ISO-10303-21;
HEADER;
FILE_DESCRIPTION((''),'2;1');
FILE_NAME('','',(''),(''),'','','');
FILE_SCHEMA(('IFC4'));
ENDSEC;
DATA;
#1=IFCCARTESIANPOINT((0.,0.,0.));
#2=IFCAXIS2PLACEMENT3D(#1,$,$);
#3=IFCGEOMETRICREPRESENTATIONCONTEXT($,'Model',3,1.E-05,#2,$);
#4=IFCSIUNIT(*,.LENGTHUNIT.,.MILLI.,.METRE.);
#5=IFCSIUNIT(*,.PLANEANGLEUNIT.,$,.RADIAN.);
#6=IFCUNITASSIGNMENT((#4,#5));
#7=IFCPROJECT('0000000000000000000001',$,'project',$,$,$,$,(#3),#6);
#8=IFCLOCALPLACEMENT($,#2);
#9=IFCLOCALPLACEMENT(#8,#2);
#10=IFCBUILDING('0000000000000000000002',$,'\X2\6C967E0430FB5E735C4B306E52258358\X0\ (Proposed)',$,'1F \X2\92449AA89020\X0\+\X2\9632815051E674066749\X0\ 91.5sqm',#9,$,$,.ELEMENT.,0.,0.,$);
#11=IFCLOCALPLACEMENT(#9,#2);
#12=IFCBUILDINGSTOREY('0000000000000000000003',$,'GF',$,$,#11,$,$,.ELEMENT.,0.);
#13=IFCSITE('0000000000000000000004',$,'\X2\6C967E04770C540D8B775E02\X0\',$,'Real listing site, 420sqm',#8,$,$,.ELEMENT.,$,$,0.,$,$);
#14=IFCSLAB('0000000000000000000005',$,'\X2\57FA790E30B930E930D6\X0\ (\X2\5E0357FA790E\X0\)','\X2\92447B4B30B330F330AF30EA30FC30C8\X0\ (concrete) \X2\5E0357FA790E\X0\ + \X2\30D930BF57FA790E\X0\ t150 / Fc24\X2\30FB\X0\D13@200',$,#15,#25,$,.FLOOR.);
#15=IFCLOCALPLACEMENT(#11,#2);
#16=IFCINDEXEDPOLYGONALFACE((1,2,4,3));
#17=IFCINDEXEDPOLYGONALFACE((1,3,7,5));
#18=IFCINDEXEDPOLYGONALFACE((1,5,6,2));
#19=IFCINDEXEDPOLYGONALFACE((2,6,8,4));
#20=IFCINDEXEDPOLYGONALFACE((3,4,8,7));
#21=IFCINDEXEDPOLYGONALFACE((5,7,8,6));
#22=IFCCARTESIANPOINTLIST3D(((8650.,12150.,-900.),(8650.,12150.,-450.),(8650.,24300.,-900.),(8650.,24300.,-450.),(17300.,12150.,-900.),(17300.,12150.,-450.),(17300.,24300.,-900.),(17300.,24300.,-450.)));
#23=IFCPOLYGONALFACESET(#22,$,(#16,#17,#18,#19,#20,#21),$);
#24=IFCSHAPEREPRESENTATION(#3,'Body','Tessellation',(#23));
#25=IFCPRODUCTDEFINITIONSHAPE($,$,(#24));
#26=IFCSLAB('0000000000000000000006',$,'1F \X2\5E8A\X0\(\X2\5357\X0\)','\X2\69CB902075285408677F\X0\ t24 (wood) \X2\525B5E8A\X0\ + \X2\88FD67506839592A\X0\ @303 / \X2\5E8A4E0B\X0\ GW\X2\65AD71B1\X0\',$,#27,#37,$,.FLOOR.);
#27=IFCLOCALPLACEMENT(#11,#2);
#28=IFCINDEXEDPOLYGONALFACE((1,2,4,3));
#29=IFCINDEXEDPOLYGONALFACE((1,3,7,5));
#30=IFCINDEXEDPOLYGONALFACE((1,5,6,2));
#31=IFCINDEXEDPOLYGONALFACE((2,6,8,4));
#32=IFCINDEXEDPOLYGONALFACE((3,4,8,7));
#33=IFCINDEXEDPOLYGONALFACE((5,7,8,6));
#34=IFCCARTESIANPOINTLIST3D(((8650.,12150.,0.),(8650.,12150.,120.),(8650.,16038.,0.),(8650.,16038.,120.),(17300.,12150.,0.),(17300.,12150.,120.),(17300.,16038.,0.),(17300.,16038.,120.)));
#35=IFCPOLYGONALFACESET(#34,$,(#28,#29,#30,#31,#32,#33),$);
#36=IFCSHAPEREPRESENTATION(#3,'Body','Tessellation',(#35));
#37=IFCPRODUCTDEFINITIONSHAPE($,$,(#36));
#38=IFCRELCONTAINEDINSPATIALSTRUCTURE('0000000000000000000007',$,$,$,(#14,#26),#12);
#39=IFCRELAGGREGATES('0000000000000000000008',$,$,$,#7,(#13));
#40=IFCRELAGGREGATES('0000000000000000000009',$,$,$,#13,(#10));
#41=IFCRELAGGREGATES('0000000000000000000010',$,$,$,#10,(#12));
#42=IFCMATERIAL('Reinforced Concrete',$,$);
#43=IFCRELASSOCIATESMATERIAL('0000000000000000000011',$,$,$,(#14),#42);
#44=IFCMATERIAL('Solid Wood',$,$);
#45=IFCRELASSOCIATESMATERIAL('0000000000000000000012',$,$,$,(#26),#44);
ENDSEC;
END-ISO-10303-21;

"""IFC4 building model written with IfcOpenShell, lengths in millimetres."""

from ifc_helpers import new_model, si_unit, frame, frame_2d, origin, place, context, project, spatial, rectangle, extrude, material, element, save


model = new_model("IFC4")

# Units and contexts
model_context = context("Model", 3, precision=1e-05, world=origin())
ifc_project = project(units=[si_unit("LENGTHUNIT", "METRE", prefix="MILLI"), si_unit("PLANEANGLEUNIT", "RADIAN")], contexts=[model_context])

# Site, building, storey
site_placement = place(None, origin())
site = spatial("IfcSite", under=ifc_project, at=site_placement, Name="沖縄県名護市", ObjectType="Real listing site, 420sqm", CompositionType="ELEMENT", RefElevation=0.0)
building_placement = place(site_placement, origin())
building = spatial("IfcBuilding", under=site, at=building_placement, Name="沖縄・平屋の別荘 (Proposed)", ObjectType="1F 鉄骨造+防腐処理杉 91.5sqm", CompositionType="ELEMENT", ElevationOfRefHeight=0.0, ElevationOfTerrain=0.0)
storey_placement = place(building_placement, origin())
storey = spatial("IfcBuildingStorey", under=building, at=storey_placement, Name="GF", CompositionType="ELEMENT", Elevation=0.0)

# Shared definitions
ifc_material_1 = material(Name="Solid Wood")

# Slabs
ifc_material_2 = material(Name="Reinforced Concrete")
slab_1_placement = place(storey_placement, frame((4325.0, 6075.0, -450.0)))
element("IfcSlab", 1, at=slab_1_placement, inside=storey, material=ifc_material_2, Name="基礎スラブ (布基礎)", Description="鉄筋コンクリート (concrete) 布基礎 + ベタ基礎 t150 / Fc24・D13@200", PredefinedType="FLOOR", context=model_context, shape_type="SweptSolid", body=[
    extrude(rectangle(XDim=8650.0, YDim=12150.0, at=frame_2d((4325.0, 6075.0))), frame((4325.0, 6075.0, -450.0)), (0.0, 0.0, 1.0), 450.0),
])
slab_2_placement = place(storey_placement, frame((4325.0, 6075.0, 0.0)))
element("IfcSlab", 2, at=slab_2_placement, inside=storey, material=ifc_material_1, Name="1F 床(南)", Description="構造用合板 t24 (wood) 剛床 + 製材根太 @303 / 床下 GW断熱", PredefinedType="FLOOR", context=model_context, shape_type="SweptSolid", body=[
    extrude(rectangle(XDim=8650.0, YDim=3888.0, at=frame_2d((4325.0, 1944.0))), frame((4325.0, 6075.0, 0.0)), (0.0, 0.0, 1.0), 120.0),
])

save(model, "model.ifc")
